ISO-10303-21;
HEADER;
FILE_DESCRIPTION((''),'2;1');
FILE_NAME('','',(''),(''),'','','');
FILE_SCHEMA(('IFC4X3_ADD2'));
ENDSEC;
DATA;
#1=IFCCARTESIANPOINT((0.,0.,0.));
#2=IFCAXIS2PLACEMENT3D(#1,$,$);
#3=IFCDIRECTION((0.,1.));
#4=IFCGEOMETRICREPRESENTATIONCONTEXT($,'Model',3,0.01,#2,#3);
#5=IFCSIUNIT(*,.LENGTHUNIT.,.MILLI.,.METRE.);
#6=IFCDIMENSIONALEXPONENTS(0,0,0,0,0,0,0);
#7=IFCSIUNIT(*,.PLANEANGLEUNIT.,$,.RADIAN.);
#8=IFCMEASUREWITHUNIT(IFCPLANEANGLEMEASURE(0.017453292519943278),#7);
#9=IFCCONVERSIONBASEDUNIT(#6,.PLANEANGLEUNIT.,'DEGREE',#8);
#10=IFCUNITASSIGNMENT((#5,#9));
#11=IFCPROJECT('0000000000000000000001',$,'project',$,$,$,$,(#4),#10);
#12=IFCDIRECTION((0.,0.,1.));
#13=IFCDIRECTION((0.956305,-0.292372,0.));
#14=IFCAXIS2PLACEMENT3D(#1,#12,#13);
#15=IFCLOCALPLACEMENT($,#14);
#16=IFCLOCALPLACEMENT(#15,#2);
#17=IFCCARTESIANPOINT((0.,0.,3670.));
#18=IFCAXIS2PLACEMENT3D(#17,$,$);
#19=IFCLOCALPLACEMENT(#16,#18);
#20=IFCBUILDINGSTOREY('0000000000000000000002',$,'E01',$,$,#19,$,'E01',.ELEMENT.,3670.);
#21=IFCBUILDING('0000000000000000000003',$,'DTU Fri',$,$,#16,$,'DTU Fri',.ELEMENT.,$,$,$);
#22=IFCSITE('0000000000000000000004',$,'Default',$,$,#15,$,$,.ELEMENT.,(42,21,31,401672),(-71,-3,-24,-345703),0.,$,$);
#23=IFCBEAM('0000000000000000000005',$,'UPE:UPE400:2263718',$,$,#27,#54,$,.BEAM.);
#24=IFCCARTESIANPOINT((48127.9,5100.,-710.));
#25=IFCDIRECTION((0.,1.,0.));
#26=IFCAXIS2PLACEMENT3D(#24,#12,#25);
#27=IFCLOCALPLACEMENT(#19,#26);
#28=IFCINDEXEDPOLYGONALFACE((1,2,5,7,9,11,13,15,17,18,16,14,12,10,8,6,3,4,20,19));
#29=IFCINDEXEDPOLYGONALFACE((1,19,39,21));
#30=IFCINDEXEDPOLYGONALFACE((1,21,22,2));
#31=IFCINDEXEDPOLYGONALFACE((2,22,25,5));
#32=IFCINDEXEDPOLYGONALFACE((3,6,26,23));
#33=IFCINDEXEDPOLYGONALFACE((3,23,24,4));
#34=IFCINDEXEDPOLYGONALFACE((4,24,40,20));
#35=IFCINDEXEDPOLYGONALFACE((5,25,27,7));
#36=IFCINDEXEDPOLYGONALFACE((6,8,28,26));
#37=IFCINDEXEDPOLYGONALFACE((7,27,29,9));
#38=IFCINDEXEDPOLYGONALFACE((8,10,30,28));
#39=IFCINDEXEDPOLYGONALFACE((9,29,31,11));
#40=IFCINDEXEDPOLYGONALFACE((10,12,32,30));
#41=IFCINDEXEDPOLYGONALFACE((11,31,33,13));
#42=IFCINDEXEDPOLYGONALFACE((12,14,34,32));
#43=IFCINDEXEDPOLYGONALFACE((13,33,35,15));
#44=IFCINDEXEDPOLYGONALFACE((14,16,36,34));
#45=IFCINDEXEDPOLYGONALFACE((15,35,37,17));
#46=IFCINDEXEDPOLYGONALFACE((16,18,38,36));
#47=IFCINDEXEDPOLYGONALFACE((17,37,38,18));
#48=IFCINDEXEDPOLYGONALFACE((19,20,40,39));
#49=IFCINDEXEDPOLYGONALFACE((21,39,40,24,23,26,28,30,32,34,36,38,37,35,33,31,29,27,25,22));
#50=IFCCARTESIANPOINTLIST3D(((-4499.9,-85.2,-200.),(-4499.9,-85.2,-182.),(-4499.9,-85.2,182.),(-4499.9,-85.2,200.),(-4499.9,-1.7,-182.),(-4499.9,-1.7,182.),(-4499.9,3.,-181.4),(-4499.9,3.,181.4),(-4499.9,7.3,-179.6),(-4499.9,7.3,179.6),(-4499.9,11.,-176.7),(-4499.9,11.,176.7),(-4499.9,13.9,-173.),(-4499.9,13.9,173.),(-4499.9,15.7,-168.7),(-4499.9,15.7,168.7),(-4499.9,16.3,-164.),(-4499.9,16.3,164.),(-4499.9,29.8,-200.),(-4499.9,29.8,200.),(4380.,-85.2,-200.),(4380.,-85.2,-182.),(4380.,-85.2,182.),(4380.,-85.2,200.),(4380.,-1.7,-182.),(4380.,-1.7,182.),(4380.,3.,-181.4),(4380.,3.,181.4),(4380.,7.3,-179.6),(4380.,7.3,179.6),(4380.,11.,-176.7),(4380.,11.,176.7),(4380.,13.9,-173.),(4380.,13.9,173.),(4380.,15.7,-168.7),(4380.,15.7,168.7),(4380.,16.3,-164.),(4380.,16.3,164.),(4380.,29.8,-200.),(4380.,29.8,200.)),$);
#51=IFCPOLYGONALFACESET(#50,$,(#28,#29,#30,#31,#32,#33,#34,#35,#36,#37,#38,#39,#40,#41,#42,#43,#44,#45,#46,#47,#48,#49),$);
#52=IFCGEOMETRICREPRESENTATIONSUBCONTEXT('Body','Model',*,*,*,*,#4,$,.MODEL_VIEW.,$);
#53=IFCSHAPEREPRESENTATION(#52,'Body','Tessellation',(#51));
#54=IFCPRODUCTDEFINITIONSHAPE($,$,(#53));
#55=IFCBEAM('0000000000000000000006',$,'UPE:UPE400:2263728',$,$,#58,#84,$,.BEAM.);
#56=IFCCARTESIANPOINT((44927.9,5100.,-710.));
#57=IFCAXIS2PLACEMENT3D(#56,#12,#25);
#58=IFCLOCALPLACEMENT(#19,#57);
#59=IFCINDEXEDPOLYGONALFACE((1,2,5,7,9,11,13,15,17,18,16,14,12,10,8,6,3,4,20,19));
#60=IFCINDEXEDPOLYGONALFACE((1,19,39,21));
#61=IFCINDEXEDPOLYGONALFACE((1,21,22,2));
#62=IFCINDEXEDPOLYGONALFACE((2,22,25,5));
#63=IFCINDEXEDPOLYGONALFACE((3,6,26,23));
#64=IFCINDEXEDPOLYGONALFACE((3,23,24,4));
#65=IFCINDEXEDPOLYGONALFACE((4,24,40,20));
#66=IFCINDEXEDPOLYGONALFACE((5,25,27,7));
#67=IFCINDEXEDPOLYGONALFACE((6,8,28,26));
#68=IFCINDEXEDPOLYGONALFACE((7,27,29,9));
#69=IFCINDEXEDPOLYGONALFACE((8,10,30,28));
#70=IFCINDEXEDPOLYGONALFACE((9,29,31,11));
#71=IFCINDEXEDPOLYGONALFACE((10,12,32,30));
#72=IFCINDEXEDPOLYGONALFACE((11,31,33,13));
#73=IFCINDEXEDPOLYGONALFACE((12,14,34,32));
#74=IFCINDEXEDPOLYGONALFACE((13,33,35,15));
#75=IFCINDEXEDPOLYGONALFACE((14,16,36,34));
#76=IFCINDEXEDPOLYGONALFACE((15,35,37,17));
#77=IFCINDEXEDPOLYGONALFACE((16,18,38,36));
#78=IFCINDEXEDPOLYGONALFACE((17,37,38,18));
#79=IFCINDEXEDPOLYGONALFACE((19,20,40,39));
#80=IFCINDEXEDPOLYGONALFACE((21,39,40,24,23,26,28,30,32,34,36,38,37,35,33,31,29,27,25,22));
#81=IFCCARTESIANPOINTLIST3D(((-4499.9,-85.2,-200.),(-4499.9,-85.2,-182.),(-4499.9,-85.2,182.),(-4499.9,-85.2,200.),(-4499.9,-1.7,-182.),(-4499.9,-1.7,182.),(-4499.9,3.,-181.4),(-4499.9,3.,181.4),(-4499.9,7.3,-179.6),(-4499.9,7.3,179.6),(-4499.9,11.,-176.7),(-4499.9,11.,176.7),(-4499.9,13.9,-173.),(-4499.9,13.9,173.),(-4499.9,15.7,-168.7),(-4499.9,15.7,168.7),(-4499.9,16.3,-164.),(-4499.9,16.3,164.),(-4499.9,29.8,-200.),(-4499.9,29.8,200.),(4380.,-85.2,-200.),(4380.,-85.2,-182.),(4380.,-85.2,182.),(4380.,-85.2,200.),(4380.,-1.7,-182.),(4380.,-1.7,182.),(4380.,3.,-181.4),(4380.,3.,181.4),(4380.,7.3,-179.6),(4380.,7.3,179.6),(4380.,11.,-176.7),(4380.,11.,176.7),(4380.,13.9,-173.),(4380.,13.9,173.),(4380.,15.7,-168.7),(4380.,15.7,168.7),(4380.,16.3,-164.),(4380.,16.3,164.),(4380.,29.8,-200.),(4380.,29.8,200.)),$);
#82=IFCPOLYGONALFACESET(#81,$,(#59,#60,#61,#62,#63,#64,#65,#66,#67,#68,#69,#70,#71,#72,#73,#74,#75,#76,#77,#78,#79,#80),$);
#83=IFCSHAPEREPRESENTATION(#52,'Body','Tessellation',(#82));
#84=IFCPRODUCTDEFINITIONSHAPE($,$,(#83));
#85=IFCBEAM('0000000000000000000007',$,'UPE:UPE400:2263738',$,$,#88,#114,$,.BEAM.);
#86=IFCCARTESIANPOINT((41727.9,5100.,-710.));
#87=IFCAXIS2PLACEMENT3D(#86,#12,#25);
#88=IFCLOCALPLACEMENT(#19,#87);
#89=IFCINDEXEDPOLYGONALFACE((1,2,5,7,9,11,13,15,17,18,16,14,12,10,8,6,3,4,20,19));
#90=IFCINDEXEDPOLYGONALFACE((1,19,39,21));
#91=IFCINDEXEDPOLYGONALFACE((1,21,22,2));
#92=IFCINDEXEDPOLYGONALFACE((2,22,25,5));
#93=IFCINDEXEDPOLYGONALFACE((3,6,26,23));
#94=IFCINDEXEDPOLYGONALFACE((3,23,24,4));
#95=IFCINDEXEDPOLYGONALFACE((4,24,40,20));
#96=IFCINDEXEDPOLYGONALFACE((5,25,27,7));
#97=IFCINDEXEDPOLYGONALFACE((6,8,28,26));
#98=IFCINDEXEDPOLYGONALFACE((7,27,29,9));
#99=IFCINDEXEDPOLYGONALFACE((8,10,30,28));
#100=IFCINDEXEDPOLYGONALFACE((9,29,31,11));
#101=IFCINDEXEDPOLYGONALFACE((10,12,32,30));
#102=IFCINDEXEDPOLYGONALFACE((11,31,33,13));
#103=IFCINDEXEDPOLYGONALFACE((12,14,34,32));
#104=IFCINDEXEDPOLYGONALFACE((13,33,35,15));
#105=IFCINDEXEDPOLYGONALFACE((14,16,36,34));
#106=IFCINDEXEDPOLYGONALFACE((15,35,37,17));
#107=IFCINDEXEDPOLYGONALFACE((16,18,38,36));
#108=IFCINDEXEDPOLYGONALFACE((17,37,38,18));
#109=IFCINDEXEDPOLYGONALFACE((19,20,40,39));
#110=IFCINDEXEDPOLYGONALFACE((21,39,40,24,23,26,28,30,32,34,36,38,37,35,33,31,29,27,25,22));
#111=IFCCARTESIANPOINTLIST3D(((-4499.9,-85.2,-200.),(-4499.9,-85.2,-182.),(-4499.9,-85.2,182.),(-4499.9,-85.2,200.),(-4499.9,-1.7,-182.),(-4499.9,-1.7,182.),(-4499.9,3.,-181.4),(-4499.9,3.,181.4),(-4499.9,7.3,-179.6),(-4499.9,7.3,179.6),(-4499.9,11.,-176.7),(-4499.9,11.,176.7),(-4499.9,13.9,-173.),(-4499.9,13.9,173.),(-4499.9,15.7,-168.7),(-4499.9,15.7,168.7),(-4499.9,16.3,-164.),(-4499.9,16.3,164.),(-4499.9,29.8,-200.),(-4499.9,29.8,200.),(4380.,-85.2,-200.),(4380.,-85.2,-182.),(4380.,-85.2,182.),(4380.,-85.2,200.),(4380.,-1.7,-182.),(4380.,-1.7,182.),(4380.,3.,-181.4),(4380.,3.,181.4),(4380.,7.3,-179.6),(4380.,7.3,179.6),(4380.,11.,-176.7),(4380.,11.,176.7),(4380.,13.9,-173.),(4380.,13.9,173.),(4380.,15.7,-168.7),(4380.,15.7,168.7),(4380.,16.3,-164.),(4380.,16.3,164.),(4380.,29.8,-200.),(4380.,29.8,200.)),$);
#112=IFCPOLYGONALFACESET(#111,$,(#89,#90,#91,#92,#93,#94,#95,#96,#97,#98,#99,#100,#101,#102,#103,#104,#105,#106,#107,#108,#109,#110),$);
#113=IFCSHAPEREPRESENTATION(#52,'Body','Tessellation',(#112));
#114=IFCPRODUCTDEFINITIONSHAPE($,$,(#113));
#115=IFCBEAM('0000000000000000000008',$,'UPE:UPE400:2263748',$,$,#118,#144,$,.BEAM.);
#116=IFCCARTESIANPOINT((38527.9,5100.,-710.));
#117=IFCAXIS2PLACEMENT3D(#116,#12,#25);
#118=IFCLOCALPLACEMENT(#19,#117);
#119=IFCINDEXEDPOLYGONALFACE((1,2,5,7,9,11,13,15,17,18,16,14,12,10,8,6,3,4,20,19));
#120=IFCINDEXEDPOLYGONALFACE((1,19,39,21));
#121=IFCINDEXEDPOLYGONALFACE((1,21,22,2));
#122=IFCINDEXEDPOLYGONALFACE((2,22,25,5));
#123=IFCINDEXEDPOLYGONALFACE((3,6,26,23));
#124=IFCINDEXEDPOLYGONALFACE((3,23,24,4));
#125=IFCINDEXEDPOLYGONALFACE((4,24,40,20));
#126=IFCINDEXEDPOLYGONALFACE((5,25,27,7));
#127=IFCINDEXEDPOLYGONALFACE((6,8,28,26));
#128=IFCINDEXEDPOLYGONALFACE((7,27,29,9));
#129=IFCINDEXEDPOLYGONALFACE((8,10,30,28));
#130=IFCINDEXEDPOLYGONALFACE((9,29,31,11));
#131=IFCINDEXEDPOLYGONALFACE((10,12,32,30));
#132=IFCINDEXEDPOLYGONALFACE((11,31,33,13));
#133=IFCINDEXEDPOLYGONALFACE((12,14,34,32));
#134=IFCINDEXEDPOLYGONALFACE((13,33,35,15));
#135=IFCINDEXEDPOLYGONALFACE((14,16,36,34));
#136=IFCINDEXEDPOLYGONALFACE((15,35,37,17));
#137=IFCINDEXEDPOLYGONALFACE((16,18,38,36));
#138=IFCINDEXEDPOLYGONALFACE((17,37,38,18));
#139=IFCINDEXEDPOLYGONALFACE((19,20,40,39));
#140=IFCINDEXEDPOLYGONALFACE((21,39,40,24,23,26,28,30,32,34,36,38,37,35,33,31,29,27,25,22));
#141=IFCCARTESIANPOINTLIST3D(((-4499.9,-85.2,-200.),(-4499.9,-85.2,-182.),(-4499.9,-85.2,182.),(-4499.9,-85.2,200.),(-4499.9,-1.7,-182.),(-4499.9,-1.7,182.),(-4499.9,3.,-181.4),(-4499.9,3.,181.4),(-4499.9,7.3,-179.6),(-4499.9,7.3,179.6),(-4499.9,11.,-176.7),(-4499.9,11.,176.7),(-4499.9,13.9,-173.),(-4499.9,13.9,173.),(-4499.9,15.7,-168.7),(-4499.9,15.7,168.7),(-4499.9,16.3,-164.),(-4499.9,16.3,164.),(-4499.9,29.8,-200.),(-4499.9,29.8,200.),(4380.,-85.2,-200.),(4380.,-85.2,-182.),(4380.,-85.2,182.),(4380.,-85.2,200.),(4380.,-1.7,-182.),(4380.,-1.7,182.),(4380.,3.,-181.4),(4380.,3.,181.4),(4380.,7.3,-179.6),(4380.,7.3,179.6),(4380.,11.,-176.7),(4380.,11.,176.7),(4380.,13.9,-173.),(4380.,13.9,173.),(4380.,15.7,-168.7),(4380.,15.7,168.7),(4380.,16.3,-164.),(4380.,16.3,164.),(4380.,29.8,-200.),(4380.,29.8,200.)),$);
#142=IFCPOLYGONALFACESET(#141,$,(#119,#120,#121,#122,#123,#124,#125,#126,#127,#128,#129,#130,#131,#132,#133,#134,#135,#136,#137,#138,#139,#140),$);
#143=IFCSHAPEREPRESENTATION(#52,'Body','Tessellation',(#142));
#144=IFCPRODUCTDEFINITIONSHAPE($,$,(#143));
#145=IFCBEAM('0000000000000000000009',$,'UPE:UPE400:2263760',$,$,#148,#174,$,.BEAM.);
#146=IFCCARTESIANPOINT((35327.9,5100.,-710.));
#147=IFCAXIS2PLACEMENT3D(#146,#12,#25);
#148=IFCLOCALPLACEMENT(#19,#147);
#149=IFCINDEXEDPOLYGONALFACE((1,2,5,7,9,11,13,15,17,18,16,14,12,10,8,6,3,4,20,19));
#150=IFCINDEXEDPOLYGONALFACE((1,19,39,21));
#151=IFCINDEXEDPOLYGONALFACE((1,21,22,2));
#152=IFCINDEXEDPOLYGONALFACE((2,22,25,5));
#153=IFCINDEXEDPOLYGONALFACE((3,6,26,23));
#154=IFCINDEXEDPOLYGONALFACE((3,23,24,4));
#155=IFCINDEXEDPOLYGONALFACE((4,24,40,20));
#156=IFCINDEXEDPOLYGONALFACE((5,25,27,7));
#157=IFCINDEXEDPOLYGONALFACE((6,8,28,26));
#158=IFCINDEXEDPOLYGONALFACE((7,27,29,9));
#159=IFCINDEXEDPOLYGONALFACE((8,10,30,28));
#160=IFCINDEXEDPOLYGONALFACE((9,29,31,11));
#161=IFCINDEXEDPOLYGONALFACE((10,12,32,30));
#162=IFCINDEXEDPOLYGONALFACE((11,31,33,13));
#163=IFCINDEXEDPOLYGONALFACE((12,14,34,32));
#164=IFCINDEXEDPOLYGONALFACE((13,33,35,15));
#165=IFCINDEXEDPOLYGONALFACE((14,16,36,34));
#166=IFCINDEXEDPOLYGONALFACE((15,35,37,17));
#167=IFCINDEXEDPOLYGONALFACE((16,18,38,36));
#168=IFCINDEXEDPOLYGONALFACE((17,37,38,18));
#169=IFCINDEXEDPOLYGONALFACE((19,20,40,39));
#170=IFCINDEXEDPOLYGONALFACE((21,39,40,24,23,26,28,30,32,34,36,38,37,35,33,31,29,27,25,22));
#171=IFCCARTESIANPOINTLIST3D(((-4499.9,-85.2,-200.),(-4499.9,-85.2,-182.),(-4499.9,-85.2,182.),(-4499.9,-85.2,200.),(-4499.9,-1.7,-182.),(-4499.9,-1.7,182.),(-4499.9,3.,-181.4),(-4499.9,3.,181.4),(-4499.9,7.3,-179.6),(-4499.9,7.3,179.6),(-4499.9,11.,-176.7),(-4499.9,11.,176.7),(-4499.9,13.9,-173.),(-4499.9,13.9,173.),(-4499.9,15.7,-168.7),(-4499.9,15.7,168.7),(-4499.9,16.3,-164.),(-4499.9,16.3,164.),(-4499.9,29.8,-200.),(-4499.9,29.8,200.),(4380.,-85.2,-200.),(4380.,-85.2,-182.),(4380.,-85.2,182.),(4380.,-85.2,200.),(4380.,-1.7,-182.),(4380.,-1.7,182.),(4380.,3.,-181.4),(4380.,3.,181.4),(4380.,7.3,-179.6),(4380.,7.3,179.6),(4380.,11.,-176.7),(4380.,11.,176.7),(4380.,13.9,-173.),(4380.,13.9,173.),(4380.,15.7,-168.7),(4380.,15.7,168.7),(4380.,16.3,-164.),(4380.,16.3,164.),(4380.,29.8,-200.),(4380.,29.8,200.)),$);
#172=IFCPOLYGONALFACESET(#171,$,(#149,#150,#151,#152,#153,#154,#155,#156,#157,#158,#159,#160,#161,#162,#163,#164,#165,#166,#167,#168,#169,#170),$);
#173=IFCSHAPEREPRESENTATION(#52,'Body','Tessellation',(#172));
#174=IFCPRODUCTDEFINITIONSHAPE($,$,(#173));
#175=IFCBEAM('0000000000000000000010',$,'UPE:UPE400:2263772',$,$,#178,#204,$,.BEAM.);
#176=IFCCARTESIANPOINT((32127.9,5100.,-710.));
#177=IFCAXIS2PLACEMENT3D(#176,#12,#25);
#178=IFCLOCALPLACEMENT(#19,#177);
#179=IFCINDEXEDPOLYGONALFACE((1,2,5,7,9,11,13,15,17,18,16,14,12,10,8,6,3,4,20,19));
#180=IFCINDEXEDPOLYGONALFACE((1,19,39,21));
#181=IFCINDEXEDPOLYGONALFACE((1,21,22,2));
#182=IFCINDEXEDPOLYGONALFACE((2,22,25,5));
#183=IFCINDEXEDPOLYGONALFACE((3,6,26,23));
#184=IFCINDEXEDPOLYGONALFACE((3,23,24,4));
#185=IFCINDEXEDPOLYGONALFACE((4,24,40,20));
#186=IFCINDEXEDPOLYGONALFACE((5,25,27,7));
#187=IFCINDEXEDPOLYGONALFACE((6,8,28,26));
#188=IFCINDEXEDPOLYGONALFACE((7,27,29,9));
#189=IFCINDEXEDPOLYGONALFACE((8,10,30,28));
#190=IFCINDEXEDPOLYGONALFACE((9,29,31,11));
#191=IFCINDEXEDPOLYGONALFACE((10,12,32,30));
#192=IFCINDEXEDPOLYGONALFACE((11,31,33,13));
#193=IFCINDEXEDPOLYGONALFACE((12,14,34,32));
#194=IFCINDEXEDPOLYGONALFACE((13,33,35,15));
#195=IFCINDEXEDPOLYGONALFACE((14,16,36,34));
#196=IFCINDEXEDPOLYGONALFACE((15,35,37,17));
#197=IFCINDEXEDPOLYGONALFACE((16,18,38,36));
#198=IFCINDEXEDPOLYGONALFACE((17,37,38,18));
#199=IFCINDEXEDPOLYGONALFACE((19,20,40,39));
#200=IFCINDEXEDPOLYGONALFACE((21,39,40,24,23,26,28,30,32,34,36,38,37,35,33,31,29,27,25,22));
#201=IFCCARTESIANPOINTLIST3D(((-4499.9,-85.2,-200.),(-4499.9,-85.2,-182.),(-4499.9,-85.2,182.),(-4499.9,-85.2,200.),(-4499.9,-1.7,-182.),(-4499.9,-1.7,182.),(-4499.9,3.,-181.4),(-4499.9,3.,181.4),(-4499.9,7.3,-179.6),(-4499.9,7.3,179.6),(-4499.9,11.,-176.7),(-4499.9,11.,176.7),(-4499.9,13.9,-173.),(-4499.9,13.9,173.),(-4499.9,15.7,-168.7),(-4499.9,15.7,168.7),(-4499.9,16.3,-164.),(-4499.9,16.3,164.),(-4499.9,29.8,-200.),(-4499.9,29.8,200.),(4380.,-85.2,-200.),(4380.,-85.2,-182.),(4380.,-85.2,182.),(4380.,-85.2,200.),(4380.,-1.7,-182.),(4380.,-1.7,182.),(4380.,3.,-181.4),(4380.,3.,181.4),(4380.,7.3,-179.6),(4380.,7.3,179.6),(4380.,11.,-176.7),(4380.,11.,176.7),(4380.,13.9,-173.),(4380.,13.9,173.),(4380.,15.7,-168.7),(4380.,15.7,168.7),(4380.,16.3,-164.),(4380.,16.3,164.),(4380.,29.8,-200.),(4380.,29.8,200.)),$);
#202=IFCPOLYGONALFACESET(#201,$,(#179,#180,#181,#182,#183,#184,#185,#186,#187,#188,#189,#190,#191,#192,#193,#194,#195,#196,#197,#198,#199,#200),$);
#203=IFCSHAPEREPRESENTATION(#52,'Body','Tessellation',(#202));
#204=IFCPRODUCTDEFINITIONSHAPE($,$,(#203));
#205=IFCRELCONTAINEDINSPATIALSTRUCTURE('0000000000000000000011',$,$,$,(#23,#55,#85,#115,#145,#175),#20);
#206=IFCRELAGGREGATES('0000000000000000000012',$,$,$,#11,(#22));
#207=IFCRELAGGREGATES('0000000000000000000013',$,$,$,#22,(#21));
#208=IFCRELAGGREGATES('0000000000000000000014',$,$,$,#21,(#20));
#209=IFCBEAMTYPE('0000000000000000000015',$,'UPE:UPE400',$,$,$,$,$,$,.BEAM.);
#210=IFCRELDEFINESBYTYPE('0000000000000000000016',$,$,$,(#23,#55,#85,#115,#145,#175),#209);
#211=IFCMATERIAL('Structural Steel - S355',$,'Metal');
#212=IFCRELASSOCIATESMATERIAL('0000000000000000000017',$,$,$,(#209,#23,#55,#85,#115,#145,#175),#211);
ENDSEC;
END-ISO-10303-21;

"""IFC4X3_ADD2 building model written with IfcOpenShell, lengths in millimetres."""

from ifc_helpers import new_model, entity, si_unit, converted_unit, direction, frame, frame_2d, origin, place, context, subcontext, project, spatial, polyline, circle_curve, parameter, trimmed, segment, composite_curve, outline, extrude, source, transform, mapped, material, material_profile, profile_set, profile_usage, type_object, type_shapes, element, save


model = new_model("IFC4X3_ADD2")

# Units and contexts
model_context = context("Model", 3, precision=0.01, world=origin(), true_north=direction((0.0, 1.0)))
body_context = subcontext(model_context, "Body", "Model", "MODEL_VIEW")
ifc_project = project(units=[si_unit("LENGTHUNIT", "METRE", prefix="MILLI"), converted_unit("PLANEANGLEUNIT", "DEGREE", entity("IfcPlaneAngleMeasure", 0.017453292519943278), si_unit("PLANEANGLEUNIT", "RADIAN"), dimensions=[0, 0, 0, 0, 0, 0, 0])], contexts=[model_context])

# Site, building, storey
site_placement = place(None, frame((0.0, 0.0, 0.0), z_axis=(0.0, 0.0, 1.0), x_axis=(0.956305, -0.292372, 0.0)))
site = spatial("IfcSite", under=ifc_project, at=site_placement, Name="Default", CompositionType="ELEMENT", RefLatitude=(42, 21, 31, 401672), RefLongitude=(-71, -3, -24, -345703), RefElevation=0.0)
building_placement = place(site_placement, origin())
building = spatial("IfcBuilding", under=site, at=building_placement, Name="DTU Fri", LongName="DTU Fri", CompositionType="ELEMENT")
storey_placement = place(building_placement, frame((0.0, 0.0, 3670.0)))
storey = spatial("IfcBuildingStorey", under=building, at=storey_placement, Name="E01", LongName="E01", CompositionType="ELEMENT", Elevation=3670.0)

# Beams
ifc_material_1 = material(Name="Structural Steel - S355", Category="Metal")
ifc_material_profile_1 = material_profile(ifc_material_1, outline(composite_curve([segment(polyline([(-200.0, -60.0), (-182.0, -60.0)]), True, "CONTINUOUS"), segment(polyline([(-182.0, -60.0), (-182.0, 23.5)]), True, "CONTINUOUS"), segment(trimmed(circle_curve(frame_2d((-164.0, 23.5), x_axis=(-1.0, 0.0)), 18.0), [parameter(270.0)], [parameter(0.0)], True, "PARAMETER"), False, "CONTINUOUS"), segment(polyline([(-164.0, 41.5), (164.0, 41.5)]), True, "CONTINUOUS"), segment(trimmed(circle_curve(frame_2d((164.0, 23.5), x_axis=(0.0, 1.0)), 18.0), [parameter(270.0)], [parameter(0.0)], True, "PARAMETER"), False, "CONTINUOUS"), segment(polyline([(182.0, 23.5), (182.0, -60.0)]), True, "CONTINUOUS"), segment(polyline([(182.0, -60.0), (200.0, -60.0)]), True, "CONTINUOUS"), segment(polyline([(200.0, -60.0), (200.0, 55.0)]), True, "CONTINUOUS"), segment(polyline([(200.0, 55.0), (-200.0, 55.0)]), True, "CONTINUOUS"), segment(polyline([(-200.0, 55.0), (-200.0, -60.0)]), True, "CONTINUOUS")], self_intersect=False)), Name="UPE400")
ifc_profile_set_1 = profile_set([ifc_material_profile_1], Name="UPE400")
ifc_profile_usage_1 = profile_usage(ifc_profile_set_1, cardinal=8)
beam_type_1 = type_object("IfcBeamType", Name="UPE:UPE400", PredefinedType="BEAM", material=ifc_profile_set_1)
shared_shape_1 = source(origin(), body_context, "Body", "SweptSolid", [
    extrude(outline(composite_curve([segment(polyline([(-200.0, -60.0), (-182.0, -60.0)]), True, "CONTINUOUS"), segment(polyline([(-182.0, -60.0), (-182.0, 23.5)]), True, "CONTINUOUS"), segment(trimmed(circle_curve(frame_2d((-164.0, 23.5), x_axis=(-1.0, 0.0)), 18.0), [parameter(270.0)], [parameter(0.0)], True, "PARAMETER"), False, "CONTINUOUS"), segment(polyline([(-164.0, 41.5), (164.0, 41.5)]), True, "CONTINUOUS"), segment(trimmed(circle_curve(frame_2d((164.0, 23.5), x_axis=(0.0, 1.0)), 18.0), [parameter(270.0)], [parameter(0.0)], True, "PARAMETER"), False, "CONTINUOUS"), segment(polyline([(182.0, 23.5), (182.0, -60.0)]), True, "CONTINUOUS"), segment(polyline([(182.0, -60.0), (200.0, -60.0)]), True, "CONTINUOUS"), segment(polyline([(200.0, -60.0), (200.0, 55.0)]), True, "CONTINUOUS"), segment(polyline([(200.0, 55.0), (-200.0, 55.0)]), True, "CONTINUOUS"), segment(polyline([(-200.0, 55.0), (-200.0, -60.0)]), True, "CONTINUOUS")], self_intersect=False)), frame((-4499.9, -25.2, 0.0), z_axis=(1.0, 0.0, 0.0), x_axis=(0.0, 0.0, -1.0)), (0.0, 0.0, 1.0), 8879.9),
])
type_shapes(beam_type_1, [shared_shape_1])
for number, where, z_axis, x_axis, name in (
    (1, (48127.9, 5100.0, -710.0), (0.0, 0.0, 1.0), (0.0, 1.0, 0.0), "UPE:UPE400:2263718"),
    (2, (44927.9, 5100.0, -710.0), (0.0, 0.0, 1.0), (0.0, 1.0, 0.0), "UPE:UPE400:2263728"),
    (3, (41727.9, 5100.0, -710.0), (0.0, 0.0, 1.0), (0.0, 1.0, 0.0), "UPE:UPE400:2263738"),
    (4, (38527.9, 5100.0, -710.0), (0.0, 0.0, 1.0), (0.0, 1.0, 0.0), "UPE:UPE400:2263748"),
    (5, (35327.9, 5100.0, -710.0), (0.0, 0.0, 1.0), (0.0, 1.0, 0.0), "UPE:UPE400:2263760"),
    (6, (32127.9, 5100.0, -710.0), (0.0, 0.0, 1.0), (0.0, 1.0, 0.0), "UPE:UPE400:2263772"),
):
    element("IfcBeam", number, at=place(storey_placement, frame(where, z_axis=z_axis, x_axis=x_axis)), inside=storey, type_object=beam_type_1, material=ifc_profile_usage_1, Name=name, PredefinedType="BEAM", context=body_context, shape_type="MappedRepresentation", body=[
        mapped(shared_shape_1, transform((0.0, 0.0, 0.0), scale=1.0)),
    ])

save(model, "model.ifc")
